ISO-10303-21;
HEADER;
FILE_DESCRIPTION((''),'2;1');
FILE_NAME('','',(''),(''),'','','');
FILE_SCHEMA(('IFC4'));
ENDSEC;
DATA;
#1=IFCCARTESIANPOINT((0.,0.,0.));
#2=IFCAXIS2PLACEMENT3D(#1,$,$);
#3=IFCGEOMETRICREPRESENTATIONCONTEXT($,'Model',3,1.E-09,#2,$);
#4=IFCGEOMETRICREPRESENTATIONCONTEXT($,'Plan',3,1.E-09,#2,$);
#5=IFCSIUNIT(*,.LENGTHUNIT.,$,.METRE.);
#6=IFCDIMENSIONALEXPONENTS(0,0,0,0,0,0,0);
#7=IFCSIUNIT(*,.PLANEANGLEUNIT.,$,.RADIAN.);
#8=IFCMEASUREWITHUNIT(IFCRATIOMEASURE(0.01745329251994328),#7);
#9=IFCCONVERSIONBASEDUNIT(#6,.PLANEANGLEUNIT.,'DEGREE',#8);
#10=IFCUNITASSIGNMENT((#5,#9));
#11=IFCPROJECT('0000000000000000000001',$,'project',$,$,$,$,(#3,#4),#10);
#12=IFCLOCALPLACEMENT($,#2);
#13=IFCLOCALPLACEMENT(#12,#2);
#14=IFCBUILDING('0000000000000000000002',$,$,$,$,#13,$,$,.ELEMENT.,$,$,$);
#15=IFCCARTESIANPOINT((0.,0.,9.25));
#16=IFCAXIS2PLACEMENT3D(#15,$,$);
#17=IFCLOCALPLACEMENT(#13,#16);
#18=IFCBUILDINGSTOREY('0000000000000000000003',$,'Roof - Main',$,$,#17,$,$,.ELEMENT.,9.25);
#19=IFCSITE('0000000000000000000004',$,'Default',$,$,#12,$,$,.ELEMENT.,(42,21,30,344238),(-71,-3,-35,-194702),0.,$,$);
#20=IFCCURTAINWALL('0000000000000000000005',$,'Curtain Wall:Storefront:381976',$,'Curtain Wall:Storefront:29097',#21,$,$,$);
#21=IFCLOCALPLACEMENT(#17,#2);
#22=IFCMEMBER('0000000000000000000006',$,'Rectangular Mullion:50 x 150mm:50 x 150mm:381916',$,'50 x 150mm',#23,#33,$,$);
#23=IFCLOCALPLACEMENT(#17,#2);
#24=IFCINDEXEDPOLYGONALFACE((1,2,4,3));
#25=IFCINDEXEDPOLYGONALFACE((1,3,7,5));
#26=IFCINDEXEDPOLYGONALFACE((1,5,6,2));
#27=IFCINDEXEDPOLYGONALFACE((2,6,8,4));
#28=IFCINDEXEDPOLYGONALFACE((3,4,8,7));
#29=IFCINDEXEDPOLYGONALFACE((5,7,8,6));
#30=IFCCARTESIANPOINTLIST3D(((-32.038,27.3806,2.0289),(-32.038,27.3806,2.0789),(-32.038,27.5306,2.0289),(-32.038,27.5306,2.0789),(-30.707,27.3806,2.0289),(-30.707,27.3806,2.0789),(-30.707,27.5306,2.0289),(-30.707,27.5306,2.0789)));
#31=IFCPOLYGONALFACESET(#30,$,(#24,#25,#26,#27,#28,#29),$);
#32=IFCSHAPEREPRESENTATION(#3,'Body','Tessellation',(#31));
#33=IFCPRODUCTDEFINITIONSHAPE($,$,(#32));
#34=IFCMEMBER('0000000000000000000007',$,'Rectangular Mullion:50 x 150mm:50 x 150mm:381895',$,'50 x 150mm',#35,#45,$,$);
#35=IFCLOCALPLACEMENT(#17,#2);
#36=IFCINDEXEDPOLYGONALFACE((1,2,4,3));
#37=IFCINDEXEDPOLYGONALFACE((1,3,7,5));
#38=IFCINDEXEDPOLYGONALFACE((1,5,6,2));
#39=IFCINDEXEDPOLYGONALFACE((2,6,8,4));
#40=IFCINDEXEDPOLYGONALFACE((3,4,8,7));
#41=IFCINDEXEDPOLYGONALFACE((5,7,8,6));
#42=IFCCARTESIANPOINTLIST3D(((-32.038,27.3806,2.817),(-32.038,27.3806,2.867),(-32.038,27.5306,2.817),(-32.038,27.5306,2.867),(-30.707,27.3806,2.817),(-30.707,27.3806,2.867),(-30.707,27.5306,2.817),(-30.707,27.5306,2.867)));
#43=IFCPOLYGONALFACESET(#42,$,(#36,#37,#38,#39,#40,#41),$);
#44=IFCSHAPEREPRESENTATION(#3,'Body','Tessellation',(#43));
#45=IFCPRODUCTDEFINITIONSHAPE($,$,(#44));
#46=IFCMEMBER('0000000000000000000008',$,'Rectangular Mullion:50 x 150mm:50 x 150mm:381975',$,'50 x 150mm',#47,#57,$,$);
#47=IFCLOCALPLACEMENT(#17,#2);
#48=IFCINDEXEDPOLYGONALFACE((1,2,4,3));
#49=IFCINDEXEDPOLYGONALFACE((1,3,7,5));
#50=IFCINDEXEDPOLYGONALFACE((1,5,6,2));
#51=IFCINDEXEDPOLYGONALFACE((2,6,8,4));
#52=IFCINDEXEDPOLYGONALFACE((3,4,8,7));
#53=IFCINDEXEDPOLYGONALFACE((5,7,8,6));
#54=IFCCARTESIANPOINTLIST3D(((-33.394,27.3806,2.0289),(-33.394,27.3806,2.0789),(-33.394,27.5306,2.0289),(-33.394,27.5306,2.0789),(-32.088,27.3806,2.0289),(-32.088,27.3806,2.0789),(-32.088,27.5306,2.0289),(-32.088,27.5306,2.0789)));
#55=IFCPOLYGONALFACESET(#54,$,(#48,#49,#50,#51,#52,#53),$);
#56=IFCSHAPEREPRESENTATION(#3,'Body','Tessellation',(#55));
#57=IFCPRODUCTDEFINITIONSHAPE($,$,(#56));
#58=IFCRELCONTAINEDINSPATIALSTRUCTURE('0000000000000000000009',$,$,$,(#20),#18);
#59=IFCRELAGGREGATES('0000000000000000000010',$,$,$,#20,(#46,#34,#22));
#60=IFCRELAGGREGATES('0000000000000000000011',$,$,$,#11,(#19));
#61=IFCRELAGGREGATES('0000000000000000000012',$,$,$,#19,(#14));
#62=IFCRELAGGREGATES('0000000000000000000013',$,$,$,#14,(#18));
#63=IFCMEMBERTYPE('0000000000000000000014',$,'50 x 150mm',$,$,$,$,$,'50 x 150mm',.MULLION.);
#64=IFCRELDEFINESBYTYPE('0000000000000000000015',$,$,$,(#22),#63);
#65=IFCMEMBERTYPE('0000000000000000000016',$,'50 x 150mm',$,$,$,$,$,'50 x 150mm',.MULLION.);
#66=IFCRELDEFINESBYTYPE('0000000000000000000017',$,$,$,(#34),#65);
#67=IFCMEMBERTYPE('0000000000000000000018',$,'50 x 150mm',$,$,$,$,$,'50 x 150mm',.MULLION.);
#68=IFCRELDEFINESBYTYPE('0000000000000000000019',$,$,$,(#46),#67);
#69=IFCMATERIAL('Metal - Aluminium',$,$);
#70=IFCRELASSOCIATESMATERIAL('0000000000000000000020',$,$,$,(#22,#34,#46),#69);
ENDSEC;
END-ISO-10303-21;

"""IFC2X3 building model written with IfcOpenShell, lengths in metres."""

from ifc_helpers import new_model, entity, si_unit, converted_unit, frame, origin, origin_2d_with_axis, place, context, project, spatial, rectangle, extrude, source, transform, mapped, material, type_object, type_shapes, element, aggregate, save


model = new_model("IFC2X3")

# Units and contexts
model_context = context("Model", 3, precision=1e-09, world=origin())
plan_context = context("Plan", 3, precision=1e-09, world=origin())
ifc_project = project(units=[si_unit("LENGTHUNIT", "METRE"), converted_unit("PLANEANGLEUNIT", "DEGREE", entity("IfcRatioMeasure", 0.01745329251994328), si_unit("PLANEANGLEUNIT", "RADIAN"), dimensions=[0, 0, 0, 0, 0, 0, 0])], contexts=[model_context, plan_context])

# Site, building, storey
site_placement = place(None, origin())
site = spatial("IfcSite", under=ifc_project, at=site_placement, Name="Default", CompositionType="ELEMENT", RefLatitude=(42, 21, 30, 344238), RefLongitude=(-71, -3, -35, -194702), RefElevation=0.0)
building_placement = place(site_placement, origin())
building = spatial("IfcBuilding", under=site, at=building_placement, CompositionType="ELEMENT")
storey_placement = place(building_placement, frame((0.0, 0.0, 9.25)))
storey = spatial("IfcBuildingStorey", under=building, at=storey_placement, Name="Roof - Main", CompositionType="ELEMENT", Elevation=9.25)

# Curtain wall
curtain_wall_1_placement = place(storey_placement, origin())
curtain_wall_1 = element("IfcCurtainWall", 1, at=curtain_wall_1_placement, inside=storey, Name="Curtain Wall:Storefront:381976", ObjectType="Curtain Wall:Storefront:29097")
ifc_material_1 = material(Name="Metal - Aluminium")

# Members
member_type_1 = type_object("IfcMemberType", Name="50 x 150mm", ElementType="50 x 150mm", PredefinedType="MULLION")
shared_shape_1 = source(origin(), model_context, "Body", "SweptSolid", [
    extrude(rectangle(XDim=0.05, YDim=0.15, at=origin_2d_with_axis()), frame((0.0, 0.0, -1.331), z_axis=(0.0, 0.0, 1.0), x_axis=(-1.0, 0.0, 0.0)), (0.0, 0.0, 1.0), 1.331),
])
type_shapes(member_type_1, [shared_shape_1])
member_1_placement = place(storey_placement, frame((-30.707, 27.4556, 2.0539), z_axis=(1.0, 0.0, 0.0), x_axis=(0.0, 0.0, 1.0)))
member_1 = element("IfcMember", 2, at=member_1_placement, type_object=member_type_1, material=ifc_material_1, Name="Rectangular Mullion:50 x 150mm:50 x 150mm:381916", ObjectType="50 x 150mm", context=model_context, shape_type="MappedRepresentation", body=[
    mapped(shared_shape_1, transform((0.0, 0.0, 0.0), scale=1.0)),
])
member_type_2 = type_object("IfcMemberType", Name="50 x 150mm", ElementType="50 x 150mm", PredefinedType="MULLION")
shared_shape_2 = source(origin(), model_context, "Body", "SweptSolid", [
    extrude(rectangle(XDim=0.05, YDim=0.15, at=origin_2d_with_axis()), frame((-0.025, 0.0, -1.331), z_axis=(0.0, 0.0, 1.0), x_axis=(-1.0, 0.0, 0.0)), (0.0, 0.0, 1.0), 1.331),
])
type_shapes(member_type_2, [shared_shape_2])
member_2_placement = place(storey_placement, frame((-30.707, 27.4556, 2.867), z_axis=(1.0, 0.0, 0.0), x_axis=(0.0, 0.0, 1.0)))
member_2 = element("IfcMember", 3, at=member_2_placement, type_object=member_type_2, material=ifc_material_1, Name="Rectangular Mullion:50 x 150mm:50 x 150mm:381895", ObjectType="50 x 150mm", context=model_context, shape_type="MappedRepresentation", body=[
    mapped(shared_shape_2, transform((0.0, 0.0, 0.0), scale=1.0)),
])
member_type_3 = type_object("IfcMemberType", Name="50 x 150mm", ElementType="50 x 150mm", PredefinedType="MULLION")
shared_shape_3 = source(origin(), model_context, "Body", "SweptSolid", [
    extrude(rectangle(XDim=0.05, YDim=0.15, at=origin_2d_with_axis()), frame((0.0, 0.0, -1.306), z_axis=(0.0, 0.0, 1.0), x_axis=(-1.0, 0.0, 0.0)), (0.0, 0.0, 1.0), 1.306),
])
type_shapes(member_type_3, [shared_shape_3])
member_3_placement = place(storey_placement, frame((-32.088, 27.4556, 2.0539), z_axis=(1.0, 0.0, 0.0), x_axis=(0.0, 0.0, 1.0)))
member_3 = element("IfcMember", 4, at=member_3_placement, type_object=member_type_3, material=ifc_material_1, Name="Rectangular Mullion:50 x 150mm:50 x 150mm:381975", ObjectType="50 x 150mm", context=model_context, shape_type="MappedRepresentation", body=[
    mapped(shared_shape_3, transform((0.0, 0.0, 0.0), scale=1.0)),
])

aggregate(curtain_wall_1, [member_3, member_2, member_1])

save(model, "model.ifc")
